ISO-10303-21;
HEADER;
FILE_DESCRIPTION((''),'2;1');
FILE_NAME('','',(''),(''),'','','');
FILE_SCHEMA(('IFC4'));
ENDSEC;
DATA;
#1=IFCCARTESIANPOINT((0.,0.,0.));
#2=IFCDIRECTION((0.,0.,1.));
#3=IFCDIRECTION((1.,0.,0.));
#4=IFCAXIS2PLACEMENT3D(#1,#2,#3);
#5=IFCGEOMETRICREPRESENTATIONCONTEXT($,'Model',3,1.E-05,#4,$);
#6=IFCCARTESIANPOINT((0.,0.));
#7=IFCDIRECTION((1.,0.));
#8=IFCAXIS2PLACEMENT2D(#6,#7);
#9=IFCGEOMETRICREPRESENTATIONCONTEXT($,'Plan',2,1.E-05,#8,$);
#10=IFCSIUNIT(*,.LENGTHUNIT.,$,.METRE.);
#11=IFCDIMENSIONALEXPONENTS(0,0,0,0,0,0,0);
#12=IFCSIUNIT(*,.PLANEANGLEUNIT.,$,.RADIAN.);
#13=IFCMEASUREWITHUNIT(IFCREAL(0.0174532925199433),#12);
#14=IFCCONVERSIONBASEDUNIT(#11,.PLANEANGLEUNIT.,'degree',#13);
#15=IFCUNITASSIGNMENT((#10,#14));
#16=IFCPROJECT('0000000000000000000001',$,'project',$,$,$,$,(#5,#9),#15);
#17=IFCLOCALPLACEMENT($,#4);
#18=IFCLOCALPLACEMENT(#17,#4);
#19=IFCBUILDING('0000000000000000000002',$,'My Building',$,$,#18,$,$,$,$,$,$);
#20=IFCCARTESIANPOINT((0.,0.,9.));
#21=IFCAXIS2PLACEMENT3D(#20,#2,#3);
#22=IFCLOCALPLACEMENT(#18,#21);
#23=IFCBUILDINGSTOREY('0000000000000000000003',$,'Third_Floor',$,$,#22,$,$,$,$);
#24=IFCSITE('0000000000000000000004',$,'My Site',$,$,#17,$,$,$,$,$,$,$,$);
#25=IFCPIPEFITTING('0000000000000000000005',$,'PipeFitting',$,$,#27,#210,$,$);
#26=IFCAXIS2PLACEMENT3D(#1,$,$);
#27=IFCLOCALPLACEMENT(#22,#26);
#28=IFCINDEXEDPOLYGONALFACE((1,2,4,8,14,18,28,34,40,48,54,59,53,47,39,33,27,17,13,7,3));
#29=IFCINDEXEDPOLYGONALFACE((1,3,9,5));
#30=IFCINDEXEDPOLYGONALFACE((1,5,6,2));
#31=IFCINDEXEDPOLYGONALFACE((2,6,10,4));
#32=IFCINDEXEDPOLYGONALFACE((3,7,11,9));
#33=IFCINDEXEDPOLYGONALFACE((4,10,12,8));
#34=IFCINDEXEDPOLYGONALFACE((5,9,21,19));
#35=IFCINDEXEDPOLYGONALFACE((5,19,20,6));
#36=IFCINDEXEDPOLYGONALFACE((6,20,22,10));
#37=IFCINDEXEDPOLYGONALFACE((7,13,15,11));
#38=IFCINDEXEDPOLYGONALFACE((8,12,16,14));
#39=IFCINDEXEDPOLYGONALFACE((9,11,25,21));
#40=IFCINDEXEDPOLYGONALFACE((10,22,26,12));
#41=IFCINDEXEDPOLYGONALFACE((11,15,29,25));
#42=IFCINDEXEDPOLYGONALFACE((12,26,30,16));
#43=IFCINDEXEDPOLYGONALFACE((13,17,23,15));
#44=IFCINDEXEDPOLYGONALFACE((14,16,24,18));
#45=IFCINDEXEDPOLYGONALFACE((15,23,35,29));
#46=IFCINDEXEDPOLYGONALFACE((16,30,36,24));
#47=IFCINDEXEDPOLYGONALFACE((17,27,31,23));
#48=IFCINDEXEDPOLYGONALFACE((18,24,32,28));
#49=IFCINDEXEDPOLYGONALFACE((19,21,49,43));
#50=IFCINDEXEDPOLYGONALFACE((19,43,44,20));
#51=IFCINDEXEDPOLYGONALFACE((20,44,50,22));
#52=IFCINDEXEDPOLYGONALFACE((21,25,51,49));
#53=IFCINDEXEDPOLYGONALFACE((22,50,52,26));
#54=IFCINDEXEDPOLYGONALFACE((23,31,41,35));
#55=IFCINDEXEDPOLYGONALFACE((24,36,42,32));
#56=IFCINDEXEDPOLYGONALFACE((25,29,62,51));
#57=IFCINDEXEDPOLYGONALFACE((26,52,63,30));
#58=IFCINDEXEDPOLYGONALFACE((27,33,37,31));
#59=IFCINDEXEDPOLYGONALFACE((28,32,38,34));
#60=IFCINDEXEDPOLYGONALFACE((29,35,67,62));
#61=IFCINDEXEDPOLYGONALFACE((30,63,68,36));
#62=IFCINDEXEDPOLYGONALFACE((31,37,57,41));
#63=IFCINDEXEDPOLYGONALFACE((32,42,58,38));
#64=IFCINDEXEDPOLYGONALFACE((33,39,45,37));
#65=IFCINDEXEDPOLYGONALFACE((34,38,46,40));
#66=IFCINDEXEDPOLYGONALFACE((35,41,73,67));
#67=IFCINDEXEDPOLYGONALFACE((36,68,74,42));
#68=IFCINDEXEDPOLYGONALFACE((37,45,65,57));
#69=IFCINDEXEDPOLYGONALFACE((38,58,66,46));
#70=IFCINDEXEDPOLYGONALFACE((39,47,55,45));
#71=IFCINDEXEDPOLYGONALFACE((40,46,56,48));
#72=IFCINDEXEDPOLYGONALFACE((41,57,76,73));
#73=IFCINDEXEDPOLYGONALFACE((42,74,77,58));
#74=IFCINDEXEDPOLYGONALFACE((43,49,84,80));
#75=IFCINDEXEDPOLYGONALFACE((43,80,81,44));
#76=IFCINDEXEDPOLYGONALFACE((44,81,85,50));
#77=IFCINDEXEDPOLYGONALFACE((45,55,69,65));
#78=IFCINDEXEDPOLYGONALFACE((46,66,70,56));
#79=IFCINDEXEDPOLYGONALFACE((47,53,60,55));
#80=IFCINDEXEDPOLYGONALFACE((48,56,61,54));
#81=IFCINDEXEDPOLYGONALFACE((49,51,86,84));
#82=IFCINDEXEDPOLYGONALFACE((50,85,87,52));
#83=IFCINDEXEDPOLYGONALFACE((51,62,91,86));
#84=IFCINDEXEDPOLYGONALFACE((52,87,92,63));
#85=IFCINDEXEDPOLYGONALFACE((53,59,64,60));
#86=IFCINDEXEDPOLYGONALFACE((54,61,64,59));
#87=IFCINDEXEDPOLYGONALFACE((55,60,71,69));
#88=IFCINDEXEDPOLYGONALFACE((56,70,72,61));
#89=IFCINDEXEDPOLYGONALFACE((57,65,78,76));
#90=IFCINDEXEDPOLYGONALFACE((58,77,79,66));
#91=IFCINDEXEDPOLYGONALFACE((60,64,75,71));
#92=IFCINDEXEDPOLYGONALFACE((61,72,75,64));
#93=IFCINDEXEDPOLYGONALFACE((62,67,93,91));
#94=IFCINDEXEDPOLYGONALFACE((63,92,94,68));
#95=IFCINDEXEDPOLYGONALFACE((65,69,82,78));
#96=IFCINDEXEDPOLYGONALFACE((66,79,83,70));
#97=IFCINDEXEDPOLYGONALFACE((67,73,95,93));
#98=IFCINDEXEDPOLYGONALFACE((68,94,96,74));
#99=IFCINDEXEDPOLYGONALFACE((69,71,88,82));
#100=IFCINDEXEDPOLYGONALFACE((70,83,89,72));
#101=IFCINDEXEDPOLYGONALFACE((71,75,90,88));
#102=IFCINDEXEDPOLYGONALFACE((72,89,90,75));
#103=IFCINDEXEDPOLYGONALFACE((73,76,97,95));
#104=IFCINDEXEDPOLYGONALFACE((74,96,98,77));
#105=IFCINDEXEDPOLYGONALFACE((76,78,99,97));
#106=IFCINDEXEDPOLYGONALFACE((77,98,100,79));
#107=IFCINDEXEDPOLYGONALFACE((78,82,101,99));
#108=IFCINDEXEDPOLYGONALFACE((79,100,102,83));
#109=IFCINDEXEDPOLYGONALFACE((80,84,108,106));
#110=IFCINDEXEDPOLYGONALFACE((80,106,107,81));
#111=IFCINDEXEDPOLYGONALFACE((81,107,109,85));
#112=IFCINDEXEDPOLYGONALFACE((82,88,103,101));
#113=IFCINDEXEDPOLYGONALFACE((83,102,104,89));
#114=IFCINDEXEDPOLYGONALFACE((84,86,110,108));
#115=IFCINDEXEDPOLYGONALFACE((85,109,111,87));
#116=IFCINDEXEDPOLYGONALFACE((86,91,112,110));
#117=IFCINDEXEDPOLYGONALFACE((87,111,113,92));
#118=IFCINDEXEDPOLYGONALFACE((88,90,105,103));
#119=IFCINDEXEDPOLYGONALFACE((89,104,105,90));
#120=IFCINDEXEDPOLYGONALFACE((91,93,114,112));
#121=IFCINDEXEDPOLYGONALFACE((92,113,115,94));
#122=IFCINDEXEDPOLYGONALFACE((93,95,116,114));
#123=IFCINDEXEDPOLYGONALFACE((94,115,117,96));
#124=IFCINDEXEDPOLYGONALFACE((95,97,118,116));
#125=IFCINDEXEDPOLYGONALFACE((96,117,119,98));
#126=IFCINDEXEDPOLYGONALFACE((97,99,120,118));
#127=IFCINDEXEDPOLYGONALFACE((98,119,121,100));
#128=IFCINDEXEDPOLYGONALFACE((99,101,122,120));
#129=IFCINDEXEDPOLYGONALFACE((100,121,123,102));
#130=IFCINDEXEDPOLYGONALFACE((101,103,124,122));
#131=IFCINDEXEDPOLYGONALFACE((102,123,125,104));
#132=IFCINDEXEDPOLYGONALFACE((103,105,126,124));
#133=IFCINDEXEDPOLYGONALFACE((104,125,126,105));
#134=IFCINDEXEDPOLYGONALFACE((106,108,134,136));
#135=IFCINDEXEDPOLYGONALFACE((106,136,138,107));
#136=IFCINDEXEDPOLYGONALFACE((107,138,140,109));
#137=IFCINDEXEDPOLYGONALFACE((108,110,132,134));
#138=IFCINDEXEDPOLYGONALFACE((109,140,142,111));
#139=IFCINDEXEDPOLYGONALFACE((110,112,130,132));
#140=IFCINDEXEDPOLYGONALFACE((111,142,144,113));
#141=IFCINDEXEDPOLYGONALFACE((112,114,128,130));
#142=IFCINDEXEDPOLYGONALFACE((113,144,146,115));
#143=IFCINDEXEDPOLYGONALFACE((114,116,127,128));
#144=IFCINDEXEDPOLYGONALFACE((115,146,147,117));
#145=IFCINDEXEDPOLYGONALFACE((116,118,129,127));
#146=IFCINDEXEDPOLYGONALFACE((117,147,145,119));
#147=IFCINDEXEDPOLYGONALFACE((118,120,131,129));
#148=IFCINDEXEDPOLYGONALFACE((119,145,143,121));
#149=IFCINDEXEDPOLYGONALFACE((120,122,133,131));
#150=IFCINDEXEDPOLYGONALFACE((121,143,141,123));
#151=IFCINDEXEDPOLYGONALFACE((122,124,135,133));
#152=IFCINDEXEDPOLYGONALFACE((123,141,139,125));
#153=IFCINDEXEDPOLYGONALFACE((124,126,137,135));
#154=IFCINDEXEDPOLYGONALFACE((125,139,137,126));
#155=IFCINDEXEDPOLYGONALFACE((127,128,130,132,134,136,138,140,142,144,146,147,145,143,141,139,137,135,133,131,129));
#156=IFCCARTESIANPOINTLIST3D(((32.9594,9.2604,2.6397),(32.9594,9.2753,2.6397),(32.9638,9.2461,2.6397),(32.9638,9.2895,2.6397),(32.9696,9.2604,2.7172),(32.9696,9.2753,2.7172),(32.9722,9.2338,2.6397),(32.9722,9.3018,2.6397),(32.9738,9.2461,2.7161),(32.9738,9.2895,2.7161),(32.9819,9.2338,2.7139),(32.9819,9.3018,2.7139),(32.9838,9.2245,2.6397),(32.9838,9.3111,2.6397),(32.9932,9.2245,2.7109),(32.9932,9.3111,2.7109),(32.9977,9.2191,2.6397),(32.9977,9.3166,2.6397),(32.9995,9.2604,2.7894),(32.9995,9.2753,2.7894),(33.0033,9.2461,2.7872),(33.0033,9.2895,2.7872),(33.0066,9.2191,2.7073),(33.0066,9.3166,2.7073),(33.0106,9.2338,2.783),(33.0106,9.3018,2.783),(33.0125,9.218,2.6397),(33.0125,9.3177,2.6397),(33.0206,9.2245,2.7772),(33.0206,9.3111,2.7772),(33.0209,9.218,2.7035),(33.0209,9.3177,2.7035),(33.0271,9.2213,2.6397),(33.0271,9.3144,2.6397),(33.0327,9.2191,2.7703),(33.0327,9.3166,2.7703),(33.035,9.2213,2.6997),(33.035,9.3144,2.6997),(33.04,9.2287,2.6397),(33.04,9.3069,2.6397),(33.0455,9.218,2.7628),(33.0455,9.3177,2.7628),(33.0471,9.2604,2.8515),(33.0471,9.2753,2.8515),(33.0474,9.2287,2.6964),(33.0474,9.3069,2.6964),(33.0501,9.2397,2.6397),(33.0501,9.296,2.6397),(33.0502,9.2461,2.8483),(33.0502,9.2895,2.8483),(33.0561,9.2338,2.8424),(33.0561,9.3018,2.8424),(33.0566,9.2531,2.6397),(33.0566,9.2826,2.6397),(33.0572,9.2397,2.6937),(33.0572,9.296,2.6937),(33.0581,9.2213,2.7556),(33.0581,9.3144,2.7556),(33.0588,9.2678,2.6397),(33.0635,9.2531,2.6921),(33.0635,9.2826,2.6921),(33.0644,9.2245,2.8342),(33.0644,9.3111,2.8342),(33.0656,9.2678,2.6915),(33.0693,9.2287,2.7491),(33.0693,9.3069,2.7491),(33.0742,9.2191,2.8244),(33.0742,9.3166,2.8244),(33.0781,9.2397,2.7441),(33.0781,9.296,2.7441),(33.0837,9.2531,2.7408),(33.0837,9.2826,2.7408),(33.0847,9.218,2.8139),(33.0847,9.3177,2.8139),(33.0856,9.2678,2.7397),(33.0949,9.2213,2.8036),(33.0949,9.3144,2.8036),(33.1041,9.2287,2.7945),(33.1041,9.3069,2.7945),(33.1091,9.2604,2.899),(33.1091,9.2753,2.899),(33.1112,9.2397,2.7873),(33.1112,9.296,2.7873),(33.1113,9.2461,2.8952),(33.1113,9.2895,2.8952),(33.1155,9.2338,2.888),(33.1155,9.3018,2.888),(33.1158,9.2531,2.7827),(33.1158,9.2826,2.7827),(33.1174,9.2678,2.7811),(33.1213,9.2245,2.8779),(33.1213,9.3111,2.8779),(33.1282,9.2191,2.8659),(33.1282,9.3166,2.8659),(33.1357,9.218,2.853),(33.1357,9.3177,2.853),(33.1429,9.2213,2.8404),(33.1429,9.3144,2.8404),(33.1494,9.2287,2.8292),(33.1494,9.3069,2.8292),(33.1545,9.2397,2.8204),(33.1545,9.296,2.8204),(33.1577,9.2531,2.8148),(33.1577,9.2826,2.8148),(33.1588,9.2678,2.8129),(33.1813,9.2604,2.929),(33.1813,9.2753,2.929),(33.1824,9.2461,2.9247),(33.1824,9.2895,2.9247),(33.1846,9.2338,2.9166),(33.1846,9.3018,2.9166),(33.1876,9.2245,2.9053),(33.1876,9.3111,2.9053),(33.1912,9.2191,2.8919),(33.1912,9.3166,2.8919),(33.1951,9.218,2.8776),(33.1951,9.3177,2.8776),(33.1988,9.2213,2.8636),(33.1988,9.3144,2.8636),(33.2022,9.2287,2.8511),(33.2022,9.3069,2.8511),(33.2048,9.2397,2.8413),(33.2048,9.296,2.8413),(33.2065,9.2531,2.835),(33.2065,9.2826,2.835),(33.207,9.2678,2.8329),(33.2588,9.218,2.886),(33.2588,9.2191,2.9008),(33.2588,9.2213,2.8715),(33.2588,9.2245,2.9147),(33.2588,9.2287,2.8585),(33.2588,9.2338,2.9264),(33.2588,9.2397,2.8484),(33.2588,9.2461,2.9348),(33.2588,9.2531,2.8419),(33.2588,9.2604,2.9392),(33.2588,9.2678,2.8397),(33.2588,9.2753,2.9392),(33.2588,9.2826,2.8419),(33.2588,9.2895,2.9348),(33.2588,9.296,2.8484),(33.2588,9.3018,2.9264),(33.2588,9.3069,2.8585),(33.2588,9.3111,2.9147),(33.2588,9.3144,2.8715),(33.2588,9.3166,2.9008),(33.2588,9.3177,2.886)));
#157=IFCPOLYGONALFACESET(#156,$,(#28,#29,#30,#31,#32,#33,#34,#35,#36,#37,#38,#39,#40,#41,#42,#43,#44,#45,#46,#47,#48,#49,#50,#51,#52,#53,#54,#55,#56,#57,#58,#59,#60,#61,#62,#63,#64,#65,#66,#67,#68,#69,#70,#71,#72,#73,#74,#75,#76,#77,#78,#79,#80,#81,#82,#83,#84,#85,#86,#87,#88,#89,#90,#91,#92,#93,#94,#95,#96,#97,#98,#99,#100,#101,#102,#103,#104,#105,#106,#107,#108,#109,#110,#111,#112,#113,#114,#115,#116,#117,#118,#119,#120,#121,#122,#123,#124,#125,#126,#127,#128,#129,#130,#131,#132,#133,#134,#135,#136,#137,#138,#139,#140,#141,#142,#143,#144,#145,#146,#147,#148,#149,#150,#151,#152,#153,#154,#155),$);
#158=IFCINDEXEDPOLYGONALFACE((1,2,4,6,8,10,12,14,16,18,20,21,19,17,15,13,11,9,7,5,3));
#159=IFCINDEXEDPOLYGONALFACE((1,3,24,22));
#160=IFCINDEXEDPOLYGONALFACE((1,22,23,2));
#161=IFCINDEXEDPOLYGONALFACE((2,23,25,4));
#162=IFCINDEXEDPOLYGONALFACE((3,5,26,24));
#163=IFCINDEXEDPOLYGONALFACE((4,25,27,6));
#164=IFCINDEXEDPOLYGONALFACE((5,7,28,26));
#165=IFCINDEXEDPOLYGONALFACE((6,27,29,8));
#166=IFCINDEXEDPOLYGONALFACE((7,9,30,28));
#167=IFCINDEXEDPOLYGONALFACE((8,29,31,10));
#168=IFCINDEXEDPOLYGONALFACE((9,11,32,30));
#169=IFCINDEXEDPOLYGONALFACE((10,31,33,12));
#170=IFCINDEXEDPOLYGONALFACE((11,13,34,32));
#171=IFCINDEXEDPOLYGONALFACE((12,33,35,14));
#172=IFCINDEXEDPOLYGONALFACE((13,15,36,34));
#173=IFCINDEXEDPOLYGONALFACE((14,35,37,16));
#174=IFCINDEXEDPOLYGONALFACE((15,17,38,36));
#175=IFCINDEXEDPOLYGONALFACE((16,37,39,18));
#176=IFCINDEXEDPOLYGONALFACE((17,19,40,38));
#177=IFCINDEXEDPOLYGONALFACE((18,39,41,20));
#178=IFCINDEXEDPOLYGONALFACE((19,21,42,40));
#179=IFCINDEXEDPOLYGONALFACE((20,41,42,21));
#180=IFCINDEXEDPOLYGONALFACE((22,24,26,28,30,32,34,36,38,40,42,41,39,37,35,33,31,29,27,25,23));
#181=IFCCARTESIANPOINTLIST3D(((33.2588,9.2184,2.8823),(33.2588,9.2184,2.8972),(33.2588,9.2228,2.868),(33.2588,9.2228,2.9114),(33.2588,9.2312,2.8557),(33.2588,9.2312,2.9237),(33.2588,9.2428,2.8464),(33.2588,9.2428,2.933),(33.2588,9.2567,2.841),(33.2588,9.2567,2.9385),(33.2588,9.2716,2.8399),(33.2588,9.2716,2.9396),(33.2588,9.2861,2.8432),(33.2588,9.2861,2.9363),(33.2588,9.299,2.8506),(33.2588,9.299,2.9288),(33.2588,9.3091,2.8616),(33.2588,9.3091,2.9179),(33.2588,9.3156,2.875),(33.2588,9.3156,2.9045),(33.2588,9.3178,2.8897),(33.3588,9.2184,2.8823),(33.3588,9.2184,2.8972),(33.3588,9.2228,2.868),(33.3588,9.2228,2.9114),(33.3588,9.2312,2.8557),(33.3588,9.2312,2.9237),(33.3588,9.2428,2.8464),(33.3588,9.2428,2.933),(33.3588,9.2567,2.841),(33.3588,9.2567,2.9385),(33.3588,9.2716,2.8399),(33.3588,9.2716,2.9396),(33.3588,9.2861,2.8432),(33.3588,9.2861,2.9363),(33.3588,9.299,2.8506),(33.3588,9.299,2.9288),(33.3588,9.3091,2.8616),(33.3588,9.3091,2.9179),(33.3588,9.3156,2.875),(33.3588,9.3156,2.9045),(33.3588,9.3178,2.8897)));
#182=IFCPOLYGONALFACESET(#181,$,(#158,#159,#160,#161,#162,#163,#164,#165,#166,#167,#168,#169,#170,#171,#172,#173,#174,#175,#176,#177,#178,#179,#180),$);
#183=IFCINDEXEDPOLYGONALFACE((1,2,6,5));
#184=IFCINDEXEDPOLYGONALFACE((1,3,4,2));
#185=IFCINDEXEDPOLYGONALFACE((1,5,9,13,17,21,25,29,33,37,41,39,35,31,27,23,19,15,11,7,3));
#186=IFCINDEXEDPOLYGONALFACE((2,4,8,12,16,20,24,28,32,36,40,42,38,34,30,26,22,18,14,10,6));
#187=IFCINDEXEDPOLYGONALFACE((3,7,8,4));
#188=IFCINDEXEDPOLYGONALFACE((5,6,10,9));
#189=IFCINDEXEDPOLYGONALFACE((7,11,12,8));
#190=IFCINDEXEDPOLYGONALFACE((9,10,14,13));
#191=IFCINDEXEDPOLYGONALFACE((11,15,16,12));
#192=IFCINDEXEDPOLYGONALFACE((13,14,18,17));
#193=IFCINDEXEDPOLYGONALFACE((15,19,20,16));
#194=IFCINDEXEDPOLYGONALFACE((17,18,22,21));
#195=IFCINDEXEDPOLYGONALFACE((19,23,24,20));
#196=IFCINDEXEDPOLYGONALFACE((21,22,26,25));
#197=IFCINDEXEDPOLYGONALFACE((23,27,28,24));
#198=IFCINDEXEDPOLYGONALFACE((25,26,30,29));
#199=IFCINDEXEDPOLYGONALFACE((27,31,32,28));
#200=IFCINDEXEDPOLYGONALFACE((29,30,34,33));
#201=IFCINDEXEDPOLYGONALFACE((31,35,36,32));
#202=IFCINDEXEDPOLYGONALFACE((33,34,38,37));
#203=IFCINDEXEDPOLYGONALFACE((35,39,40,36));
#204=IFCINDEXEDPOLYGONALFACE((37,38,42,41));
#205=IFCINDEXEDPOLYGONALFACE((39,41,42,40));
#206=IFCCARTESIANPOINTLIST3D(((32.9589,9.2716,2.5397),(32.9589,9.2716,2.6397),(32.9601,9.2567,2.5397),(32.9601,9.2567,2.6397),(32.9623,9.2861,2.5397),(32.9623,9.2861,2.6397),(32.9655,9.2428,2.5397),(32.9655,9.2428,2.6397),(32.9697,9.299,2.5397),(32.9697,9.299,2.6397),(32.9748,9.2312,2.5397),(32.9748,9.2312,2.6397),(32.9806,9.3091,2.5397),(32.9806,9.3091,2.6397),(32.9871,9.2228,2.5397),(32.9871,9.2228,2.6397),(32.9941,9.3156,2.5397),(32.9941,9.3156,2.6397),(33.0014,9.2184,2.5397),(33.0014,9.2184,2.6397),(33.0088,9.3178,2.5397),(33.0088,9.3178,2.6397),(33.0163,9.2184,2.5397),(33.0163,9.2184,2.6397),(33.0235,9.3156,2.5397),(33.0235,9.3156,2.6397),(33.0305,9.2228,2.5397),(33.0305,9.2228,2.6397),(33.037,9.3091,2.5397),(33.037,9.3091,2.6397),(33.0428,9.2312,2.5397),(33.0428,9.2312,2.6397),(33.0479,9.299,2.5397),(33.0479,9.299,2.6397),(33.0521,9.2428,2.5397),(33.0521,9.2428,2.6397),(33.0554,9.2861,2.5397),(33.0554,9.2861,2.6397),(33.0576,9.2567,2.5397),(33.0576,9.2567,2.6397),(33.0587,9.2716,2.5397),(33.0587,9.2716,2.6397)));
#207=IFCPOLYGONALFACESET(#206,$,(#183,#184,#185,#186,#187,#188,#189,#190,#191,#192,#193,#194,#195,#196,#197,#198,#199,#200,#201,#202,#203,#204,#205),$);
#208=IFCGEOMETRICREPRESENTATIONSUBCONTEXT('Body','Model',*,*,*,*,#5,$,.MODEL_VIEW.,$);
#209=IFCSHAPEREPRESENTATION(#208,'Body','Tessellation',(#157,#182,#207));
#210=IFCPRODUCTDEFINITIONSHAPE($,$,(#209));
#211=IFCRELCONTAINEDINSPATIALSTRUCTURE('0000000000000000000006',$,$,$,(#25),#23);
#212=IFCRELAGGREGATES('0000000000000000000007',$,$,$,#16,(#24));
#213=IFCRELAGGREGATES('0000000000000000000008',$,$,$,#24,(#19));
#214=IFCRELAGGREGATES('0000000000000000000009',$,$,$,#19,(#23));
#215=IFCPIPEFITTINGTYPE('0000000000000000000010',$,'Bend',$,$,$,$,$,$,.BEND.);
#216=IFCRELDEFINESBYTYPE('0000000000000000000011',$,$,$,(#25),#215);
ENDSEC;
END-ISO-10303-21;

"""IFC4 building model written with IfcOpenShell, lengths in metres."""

from ifc_helpers import new_model, entity, si_unit, converted_unit, frame, origin_with_axes, origin_2d_with_axis, place, context, subcontext, project, spatial, circle, extrude, source, transform, mapped, type_object, type_shapes, element, save


model = new_model("IFC4")

# Units and contexts
model_context = context("Model", 3, precision=1e-05, world=origin_with_axes())
plan_context = context("Plan", 2, precision=1e-05, world=origin_2d_with_axis())
body_context_1 = subcontext(model_context, "Body", "Model", "MODEL_VIEW")
ifc_project = project(units=[si_unit("LENGTHUNIT", "METRE"), converted_unit("PLANEANGLEUNIT", "degree", entity("IfcReal", 0.0174532925199433), si_unit("PLANEANGLEUNIT", "RADIAN"), dimensions=[0, 0, 0, 0, 0, 0, 0])], contexts=[model_context, plan_context])

# Site, building, storey
site_placement = place(None, origin_with_axes())
site = spatial("IfcSite", under=ifc_project, at=site_placement, Name="My Site")
building_placement = place(site_placement, origin_with_axes())
building = spatial("IfcBuilding", under=site, at=building_placement, Name="My Building")
storey_placement = place(building_placement, frame((0.0, 0.0, 9.0), z_axis=(0.0, 0.0, 1.0), x_axis=(1.0, 0.0, 0.0)))
storey = spatial("IfcBuildingStorey", under=building, at=storey_placement, Name="Third_Floor")

# Pipe fitting
pipe_fitting_type = type_object("IfcPipeFittingType", Name="Bend", PredefinedType="BEND")
shared_shape_1 = source(origin_with_axes(), body_context_1, "Body", "SolidModel", [
    entity("IfcSweptDiskSolid", entity("IfcIndexedPolyCurve", entity("IfcCartesianPointList3D", [[0.0, 0.0, -0.1], [0.0, -0.0732, -0.2768], [0.0, -0.25, -0.35]]), [entity("IfcArcIndex", [1, 2, 3])]), 0.05),
    extrude(circle(Radius=0.05), origin_with_axes(), (0.0, 0.0, -1.0), 0.1),
    extrude(circle(Radius=0.05), frame((0.0, -0.25, -0.35), z_axis=(0.0, -1.0, 0.0), x_axis=(1.0, 0.0, 0.0)), (0.0, 0.0, 1.0), 0.1),
])
type_shapes(pipe_fitting_type, [shared_shape_1])
for number, where, z_axis, x_axis, name in (
    (1, (33.3588, 9.2678, 2.8897), (1.0, 0.0, 0.0), (0.0, 1.0, 0.0), "PipeFitting"),
):
    element("IfcPipeFitting", number, at=place(storey_placement, frame(where, z_axis=z_axis, x_axis=x_axis)), inside=storey, type_object=pipe_fitting_type, Name=name, context=body_context_1, shape_type="MappedRepresentation", body=[
        mapped(shared_shape_1, transform((0.0, 0.0, 0.0), x_axis=(1.0, 0.0, 0.0), y_axis=(0.0, 1.0, 0.0), z_axis=(0.0, 0.0, 1.0), scale=1.0)),
    ])

save(model, "model.ifc")
